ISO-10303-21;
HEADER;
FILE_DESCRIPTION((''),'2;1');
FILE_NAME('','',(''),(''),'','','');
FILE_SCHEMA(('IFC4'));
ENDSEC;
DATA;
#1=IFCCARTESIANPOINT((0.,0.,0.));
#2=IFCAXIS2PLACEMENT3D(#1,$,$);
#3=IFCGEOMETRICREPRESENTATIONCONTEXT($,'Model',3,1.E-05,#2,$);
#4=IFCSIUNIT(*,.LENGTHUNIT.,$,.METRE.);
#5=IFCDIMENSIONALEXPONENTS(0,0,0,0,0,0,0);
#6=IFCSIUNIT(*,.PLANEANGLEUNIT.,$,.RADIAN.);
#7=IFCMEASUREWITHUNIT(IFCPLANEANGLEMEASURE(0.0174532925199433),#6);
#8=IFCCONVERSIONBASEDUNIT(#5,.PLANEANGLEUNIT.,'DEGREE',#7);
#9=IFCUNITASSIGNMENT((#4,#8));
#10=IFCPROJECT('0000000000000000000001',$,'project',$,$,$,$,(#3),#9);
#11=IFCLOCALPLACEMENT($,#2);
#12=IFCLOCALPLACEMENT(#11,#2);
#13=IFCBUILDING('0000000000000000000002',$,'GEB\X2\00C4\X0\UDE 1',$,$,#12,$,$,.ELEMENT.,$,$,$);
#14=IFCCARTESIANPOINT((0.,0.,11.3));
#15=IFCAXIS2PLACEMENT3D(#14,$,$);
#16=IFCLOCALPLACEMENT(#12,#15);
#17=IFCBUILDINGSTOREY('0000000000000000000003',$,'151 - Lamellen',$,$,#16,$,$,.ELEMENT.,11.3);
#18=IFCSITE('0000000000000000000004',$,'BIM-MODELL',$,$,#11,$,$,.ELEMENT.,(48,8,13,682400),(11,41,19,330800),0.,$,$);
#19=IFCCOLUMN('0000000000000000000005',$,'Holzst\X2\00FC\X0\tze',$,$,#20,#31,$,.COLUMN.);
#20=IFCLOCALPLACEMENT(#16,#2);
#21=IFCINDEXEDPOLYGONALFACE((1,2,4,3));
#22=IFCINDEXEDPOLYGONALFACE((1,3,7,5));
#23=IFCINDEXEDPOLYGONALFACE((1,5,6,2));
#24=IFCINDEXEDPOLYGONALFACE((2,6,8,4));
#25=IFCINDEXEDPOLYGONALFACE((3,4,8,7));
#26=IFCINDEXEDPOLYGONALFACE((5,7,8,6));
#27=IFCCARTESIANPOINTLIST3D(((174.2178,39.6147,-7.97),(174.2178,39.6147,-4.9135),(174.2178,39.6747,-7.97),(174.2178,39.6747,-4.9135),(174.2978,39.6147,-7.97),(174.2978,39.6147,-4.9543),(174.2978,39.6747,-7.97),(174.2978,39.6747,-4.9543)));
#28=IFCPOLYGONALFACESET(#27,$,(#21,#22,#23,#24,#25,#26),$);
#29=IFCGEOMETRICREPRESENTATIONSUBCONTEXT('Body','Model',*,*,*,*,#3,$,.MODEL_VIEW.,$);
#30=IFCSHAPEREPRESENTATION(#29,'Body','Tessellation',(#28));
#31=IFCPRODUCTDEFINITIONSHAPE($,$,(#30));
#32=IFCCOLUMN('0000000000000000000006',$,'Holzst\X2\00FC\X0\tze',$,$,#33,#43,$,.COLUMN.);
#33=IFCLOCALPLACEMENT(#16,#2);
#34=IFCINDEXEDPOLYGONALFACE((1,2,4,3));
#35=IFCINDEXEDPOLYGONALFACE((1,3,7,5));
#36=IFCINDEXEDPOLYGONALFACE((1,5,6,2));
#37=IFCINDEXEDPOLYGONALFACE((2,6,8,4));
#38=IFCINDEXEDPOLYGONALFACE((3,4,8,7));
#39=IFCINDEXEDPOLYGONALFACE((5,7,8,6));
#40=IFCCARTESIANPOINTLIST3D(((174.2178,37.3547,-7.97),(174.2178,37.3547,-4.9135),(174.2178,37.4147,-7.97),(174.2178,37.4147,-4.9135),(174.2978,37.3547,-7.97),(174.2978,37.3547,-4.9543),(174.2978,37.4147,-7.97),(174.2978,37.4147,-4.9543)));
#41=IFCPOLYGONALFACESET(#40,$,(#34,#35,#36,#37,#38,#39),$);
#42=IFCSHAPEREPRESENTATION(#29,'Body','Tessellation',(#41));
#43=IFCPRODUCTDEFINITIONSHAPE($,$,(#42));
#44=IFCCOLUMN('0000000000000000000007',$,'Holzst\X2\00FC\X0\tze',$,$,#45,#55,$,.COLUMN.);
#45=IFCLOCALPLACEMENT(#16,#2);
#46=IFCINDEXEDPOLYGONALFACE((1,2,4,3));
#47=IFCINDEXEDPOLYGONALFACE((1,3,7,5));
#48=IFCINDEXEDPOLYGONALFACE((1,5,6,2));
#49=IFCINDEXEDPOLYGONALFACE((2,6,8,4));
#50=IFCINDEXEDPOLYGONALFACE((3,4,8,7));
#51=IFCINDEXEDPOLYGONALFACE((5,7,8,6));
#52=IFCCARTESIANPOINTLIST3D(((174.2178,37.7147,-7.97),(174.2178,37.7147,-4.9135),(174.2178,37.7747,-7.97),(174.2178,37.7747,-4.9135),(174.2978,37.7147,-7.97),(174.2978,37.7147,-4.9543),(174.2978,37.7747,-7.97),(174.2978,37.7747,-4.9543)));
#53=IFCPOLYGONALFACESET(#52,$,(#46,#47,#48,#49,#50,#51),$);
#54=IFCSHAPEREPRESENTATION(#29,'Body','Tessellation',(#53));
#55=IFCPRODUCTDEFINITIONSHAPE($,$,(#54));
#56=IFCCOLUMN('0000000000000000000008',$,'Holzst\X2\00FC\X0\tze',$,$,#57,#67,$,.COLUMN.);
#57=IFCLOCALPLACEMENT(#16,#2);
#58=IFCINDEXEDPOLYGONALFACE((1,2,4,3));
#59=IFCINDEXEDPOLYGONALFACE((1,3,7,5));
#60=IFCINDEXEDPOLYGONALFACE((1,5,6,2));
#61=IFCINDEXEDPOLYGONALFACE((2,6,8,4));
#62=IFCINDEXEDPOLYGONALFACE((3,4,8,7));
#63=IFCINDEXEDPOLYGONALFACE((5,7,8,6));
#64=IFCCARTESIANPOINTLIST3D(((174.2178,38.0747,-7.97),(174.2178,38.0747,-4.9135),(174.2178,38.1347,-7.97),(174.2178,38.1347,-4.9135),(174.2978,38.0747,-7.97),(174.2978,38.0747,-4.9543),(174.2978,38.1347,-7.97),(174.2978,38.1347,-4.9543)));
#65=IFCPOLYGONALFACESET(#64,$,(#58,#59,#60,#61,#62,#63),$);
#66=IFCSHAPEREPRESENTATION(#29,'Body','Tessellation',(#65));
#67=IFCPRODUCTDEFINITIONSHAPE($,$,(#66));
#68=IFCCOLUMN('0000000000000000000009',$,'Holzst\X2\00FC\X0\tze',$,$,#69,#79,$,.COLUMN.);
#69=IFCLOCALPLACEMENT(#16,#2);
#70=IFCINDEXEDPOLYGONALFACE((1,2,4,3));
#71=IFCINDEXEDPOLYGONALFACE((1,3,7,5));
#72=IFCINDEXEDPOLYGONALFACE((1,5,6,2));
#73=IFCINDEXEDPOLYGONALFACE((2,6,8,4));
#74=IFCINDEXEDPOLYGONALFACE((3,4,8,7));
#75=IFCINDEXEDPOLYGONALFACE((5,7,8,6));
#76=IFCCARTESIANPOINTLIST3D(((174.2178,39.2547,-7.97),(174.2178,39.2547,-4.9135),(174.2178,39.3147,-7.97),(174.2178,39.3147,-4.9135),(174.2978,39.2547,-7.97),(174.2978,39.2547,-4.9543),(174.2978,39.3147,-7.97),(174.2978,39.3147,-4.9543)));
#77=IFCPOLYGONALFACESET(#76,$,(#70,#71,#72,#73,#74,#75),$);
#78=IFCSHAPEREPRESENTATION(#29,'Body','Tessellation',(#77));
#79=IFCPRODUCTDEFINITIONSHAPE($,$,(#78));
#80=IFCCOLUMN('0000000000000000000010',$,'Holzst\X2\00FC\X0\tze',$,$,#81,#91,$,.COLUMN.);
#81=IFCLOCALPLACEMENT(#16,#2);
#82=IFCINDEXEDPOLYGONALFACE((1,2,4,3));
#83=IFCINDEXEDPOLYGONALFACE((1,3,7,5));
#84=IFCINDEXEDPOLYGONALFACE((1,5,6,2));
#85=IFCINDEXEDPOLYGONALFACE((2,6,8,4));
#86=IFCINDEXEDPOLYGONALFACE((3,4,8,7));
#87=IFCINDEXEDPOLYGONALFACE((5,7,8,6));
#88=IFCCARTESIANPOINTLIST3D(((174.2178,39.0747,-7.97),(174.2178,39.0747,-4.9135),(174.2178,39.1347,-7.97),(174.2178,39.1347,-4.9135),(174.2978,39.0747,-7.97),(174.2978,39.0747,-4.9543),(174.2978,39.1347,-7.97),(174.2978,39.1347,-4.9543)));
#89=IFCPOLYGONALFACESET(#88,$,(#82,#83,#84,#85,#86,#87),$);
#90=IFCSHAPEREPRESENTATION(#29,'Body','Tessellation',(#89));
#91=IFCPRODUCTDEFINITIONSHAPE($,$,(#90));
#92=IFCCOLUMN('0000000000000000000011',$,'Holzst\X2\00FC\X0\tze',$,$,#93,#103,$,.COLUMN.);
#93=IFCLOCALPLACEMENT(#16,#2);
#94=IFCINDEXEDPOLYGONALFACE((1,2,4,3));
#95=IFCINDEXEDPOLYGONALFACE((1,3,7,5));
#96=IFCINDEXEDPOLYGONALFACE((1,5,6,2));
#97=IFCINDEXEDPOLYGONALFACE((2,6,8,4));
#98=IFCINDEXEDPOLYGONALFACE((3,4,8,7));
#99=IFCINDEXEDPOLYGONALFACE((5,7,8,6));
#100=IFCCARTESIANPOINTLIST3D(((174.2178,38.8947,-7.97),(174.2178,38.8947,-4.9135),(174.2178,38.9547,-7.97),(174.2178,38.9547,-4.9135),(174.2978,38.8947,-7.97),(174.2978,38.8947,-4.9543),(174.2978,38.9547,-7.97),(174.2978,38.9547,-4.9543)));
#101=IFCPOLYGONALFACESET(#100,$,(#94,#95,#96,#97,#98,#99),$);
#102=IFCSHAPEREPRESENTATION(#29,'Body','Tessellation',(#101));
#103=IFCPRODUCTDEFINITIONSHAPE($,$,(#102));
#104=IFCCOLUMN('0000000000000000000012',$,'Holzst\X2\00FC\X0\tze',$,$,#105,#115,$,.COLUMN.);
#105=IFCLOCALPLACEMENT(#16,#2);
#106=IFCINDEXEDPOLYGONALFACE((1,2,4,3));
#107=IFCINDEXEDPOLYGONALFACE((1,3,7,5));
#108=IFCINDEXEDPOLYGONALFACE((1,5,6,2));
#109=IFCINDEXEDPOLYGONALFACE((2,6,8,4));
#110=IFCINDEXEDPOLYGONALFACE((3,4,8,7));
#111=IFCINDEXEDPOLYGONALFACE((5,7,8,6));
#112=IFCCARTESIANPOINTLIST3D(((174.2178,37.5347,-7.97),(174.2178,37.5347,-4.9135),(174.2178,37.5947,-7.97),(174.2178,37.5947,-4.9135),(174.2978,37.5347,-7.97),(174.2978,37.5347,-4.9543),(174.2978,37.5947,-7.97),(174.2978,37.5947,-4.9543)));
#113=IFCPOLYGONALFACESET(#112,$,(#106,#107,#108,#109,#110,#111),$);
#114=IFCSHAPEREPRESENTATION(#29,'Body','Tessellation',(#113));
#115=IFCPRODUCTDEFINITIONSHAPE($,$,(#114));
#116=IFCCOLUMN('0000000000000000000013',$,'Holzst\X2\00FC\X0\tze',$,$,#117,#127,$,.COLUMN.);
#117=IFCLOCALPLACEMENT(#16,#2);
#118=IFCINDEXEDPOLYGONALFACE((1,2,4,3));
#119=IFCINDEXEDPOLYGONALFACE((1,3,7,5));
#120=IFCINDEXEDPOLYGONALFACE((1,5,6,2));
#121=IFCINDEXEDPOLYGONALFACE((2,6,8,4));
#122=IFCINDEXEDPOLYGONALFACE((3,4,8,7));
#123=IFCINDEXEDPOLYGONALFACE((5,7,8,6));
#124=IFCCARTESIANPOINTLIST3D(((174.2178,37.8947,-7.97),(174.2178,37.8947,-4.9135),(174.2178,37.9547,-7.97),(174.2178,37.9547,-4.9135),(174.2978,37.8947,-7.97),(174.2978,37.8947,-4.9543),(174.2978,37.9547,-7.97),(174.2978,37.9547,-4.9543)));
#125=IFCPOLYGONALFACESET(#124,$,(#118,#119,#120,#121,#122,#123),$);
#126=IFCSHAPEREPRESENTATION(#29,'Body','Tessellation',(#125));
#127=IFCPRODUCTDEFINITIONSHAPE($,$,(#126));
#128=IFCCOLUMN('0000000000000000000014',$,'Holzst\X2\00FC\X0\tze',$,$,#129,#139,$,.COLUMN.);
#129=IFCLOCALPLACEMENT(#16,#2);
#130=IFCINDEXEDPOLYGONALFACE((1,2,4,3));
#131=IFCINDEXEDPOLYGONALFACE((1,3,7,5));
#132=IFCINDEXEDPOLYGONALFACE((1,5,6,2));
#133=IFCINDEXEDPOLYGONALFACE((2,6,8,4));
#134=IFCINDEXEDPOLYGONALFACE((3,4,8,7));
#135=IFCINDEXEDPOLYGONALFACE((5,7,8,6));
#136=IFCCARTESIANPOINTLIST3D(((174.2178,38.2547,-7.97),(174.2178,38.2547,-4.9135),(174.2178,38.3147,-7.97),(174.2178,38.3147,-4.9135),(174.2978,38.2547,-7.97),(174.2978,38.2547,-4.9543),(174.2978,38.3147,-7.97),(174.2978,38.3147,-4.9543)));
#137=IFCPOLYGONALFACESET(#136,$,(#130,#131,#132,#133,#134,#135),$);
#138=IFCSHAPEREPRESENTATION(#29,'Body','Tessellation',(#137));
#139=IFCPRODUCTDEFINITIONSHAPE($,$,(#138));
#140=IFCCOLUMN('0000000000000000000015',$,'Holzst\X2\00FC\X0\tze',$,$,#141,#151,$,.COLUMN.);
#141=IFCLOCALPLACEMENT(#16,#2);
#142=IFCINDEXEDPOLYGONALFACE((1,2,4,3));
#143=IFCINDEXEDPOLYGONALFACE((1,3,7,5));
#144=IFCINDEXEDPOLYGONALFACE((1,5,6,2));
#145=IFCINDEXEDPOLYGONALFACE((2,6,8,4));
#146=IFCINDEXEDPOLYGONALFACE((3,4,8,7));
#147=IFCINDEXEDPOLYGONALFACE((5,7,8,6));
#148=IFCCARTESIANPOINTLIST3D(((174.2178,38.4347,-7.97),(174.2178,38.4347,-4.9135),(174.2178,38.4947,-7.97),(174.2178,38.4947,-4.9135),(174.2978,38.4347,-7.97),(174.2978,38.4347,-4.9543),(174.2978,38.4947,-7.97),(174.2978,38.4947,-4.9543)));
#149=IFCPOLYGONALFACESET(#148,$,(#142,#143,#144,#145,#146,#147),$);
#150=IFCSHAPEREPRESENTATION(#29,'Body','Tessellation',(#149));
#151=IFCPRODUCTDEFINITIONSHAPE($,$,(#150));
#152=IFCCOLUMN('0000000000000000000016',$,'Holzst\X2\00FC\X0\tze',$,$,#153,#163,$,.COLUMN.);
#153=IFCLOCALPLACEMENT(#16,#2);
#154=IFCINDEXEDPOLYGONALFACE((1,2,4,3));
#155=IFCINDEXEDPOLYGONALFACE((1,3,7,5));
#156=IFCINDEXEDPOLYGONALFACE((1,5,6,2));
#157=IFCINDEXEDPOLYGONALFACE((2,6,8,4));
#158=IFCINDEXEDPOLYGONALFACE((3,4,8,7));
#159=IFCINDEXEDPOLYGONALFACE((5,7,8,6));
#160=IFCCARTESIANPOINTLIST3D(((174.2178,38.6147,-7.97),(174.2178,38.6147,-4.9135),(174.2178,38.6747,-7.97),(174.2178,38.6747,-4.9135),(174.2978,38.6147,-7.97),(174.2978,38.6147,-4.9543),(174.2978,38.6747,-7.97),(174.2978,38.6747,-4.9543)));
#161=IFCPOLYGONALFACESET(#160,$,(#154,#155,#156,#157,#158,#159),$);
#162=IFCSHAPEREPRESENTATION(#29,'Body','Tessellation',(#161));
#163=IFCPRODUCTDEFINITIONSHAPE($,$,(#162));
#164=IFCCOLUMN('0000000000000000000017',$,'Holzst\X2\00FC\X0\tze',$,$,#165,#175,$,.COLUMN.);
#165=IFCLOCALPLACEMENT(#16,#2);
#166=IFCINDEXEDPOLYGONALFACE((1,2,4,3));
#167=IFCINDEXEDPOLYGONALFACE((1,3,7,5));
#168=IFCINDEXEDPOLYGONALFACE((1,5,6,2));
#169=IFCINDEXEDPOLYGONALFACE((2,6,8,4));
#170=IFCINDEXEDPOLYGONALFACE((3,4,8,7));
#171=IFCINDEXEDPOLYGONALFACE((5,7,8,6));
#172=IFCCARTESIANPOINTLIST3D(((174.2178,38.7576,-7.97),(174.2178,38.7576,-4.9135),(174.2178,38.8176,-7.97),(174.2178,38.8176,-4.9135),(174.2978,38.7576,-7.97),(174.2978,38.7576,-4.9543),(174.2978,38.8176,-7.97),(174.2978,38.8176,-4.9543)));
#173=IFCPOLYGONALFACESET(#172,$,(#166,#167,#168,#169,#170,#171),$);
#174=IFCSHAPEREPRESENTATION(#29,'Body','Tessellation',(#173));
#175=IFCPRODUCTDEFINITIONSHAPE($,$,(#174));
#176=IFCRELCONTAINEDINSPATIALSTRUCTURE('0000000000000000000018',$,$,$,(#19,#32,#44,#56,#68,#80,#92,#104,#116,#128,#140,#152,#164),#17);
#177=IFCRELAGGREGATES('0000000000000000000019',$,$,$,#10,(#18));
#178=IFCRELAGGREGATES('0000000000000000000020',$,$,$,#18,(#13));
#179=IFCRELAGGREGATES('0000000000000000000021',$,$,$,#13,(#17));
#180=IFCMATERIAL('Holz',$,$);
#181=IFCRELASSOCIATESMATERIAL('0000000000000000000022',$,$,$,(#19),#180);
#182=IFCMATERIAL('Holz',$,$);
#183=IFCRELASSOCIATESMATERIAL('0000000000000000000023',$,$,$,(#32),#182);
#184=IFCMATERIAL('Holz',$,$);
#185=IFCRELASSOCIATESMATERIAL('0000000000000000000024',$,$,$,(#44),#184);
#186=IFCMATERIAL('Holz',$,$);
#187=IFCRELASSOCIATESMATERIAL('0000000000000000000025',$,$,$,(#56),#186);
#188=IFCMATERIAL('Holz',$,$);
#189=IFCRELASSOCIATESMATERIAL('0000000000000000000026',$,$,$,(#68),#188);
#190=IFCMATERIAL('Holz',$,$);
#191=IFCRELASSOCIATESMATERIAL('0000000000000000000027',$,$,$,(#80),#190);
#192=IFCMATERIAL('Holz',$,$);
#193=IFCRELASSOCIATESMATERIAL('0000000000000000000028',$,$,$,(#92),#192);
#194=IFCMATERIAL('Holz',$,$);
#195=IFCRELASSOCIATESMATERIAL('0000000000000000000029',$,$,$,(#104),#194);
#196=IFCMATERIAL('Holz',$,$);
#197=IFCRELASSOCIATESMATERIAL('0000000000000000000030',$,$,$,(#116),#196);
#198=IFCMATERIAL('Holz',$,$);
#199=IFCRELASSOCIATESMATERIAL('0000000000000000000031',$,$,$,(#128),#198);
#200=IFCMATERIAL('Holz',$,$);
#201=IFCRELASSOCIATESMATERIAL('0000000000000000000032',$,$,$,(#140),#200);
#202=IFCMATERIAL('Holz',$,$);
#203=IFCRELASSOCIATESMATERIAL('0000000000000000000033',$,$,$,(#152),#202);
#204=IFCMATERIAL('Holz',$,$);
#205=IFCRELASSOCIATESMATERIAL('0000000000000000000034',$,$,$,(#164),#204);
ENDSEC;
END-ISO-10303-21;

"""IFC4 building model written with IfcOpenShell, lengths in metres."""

from ifc_helpers import new_model, entity, si_unit, converted_unit, frame, frame_2d, origin, origin_with_axes, place, context, subcontext, project, spatial, rectangle, extrude, clip, halfspace, material, element, save


model = new_model("IFC4")

# Units and contexts
model_context = context("Model", 3, precision=1e-05, world=origin())
body_context = subcontext(model_context, "Body", "Model", "MODEL_VIEW")
ifc_project = project(units=[si_unit("LENGTHUNIT", "METRE"), converted_unit("PLANEANGLEUNIT", "DEGREE", entity("IfcPlaneAngleMeasure", 0.0174532925199433), si_unit("PLANEANGLEUNIT", "RADIAN"), dimensions=[0, 0, 0, 0, 0, 0, 0])], contexts=[model_context])

# Site, building, storey
site_placement = place(None, origin())
site = spatial("IfcSite", under=ifc_project, at=site_placement, Name="BIM-MODELL", CompositionType="ELEMENT", RefLatitude=(48, 8, 13, 682400), RefLongitude=(11, 41, 19, 330800), RefElevation=0.0)
building_placement = place(site_placement, origin())
building = spatial("IfcBuilding", under=site, at=building_placement, Name="GEBÄUDE 1", CompositionType="ELEMENT")
storey_placement = place(building_placement, frame((0.0, 0.0, 11.3)))
storey = spatial("IfcBuildingStorey", under=building, at=storey_placement, Name="151 - Lamellen", CompositionType="ELEMENT", Elevation=11.3)

# Columns
ifc_material_1 = material(Name="Holz")
column_1_placement = place(storey_placement, frame((174.2978, 39.6147, -7.97)))
element("IfcColumn", 1, at=column_1_placement, inside=storey, material=ifc_material_1, Name="Holzstütze", PredefinedType="COLUMN", context=body_context, shape_type="Clipping", body=[
    clip(extrude(rectangle(XDim=0.06, YDim=0.08, at=frame_2d((-0.04, 0.03), x_axis=(0.0, 1.0))), origin_with_axes(), (0.0, 0.0, 1.0), 3.0565), halfspace(frame((-0.04, 0.03, 3.0361), z_axis=(-0.45399, 0.0, -0.891007), x_axis=(0.891007, 0.0, -0.45399)), True)),
])
ifc_material_2 = material(Name="Holz")
column_2_placement = place(storey_placement, frame((174.2978, 37.3547, -7.97)))
element("IfcColumn", 2, at=column_2_placement, inside=storey, material=ifc_material_2, Name="Holzstütze", PredefinedType="COLUMN", context=body_context, shape_type="Clipping", body=[
    clip(extrude(rectangle(XDim=0.06, YDim=0.08, at=frame_2d((-0.04, 0.03), x_axis=(0.0, 1.0))), origin_with_axes(), (0.0, 0.0, 1.0), 3.0565), halfspace(frame((-0.04, 0.03, 3.0361), z_axis=(-0.45399, 0.0, -0.891007), x_axis=(0.891007, 0.0, -0.45399)), True)),
])
ifc_material_3 = material(Name="Holz")
column_3_placement = place(storey_placement, frame((174.2978, 37.7147, -7.97)))
element("IfcColumn", 3, at=column_3_placement, inside=storey, material=ifc_material_3, Name="Holzstütze", PredefinedType="COLUMN", context=body_context, shape_type="Clipping", body=[
    clip(extrude(rectangle(XDim=0.06, YDim=0.08, at=frame_2d((-0.04, 0.03), x_axis=(0.0, 1.0))), origin_with_axes(), (0.0, 0.0, 1.0), 3.0565), halfspace(frame((-0.04, 0.03, 3.0361), z_axis=(-0.45399, 0.0, -0.891007), x_axis=(0.891007, 0.0, -0.45399)), True)),
])
ifc_material_4 = material(Name="Holz")
column_4_placement = place(storey_placement, frame((174.2978, 38.0747, -7.97)))
element("IfcColumn", 4, at=column_4_placement, inside=storey, material=ifc_material_4, Name="Holzstütze", PredefinedType="COLUMN", context=body_context, shape_type="Clipping", body=[
    clip(extrude(rectangle(XDim=0.06, YDim=0.08, at=frame_2d((-0.04, 0.03), x_axis=(0.0, 1.0))), origin_with_axes(), (0.0, 0.0, 1.0), 3.0565), halfspace(frame((-0.04, 0.03, 3.0361), z_axis=(-0.45399, 0.0, -0.891007), x_axis=(0.891007, 0.0, -0.45399)), True)),
])
ifc_material_5 = material(Name="Holz")
column_5_placement = place(storey_placement, frame((174.2978, 39.2547, -7.97)))
element("IfcColumn", 5, at=column_5_placement, inside=storey, material=ifc_material_5, Name="Holzstütze", PredefinedType="COLUMN", context=body_context, shape_type="Clipping", body=[
    clip(extrude(rectangle(XDim=0.06, YDim=0.08, at=frame_2d((-0.04, 0.03), x_axis=(0.0, 1.0))), origin_with_axes(), (0.0, 0.0, 1.0), 3.0565), halfspace(frame((-0.04, 0.03, 3.0361), z_axis=(-0.45399, 0.0, -0.891007), x_axis=(0.891007, 0.0, -0.45399)), True)),
])
ifc_material_6 = material(Name="Holz")
column_6_placement = place(storey_placement, frame((174.2978, 39.0747, -7.97)))
element("IfcColumn", 6, at=column_6_placement, inside=storey, material=ifc_material_6, Name="Holzstütze", PredefinedType="COLUMN", context=body_context, shape_type="Clipping", body=[
    clip(extrude(rectangle(XDim=0.06, YDim=0.08, at=frame_2d((-0.04, 0.03), x_axis=(0.0, 1.0))), origin_with_axes(), (0.0, 0.0, 1.0), 3.0565), halfspace(frame((-0.04, 0.03, 3.0361), z_axis=(-0.45399, 0.0, -0.891007), x_axis=(0.891007, 0.0, -0.45399)), True)),
])
ifc_material_7 = material(Name="Holz")
column_7_placement = place(storey_placement, frame((174.2978, 38.8947, -7.97)))
element("IfcColumn", 7, at=column_7_placement, inside=storey, material=ifc_material_7, Name="Holzstütze", PredefinedType="COLUMN", context=body_context, shape_type="Clipping", body=[
    clip(extrude(rectangle(XDim=0.06, YDim=0.08, at=frame_2d((-0.04, 0.03), x_axis=(0.0, 1.0))), origin_with_axes(), (0.0, 0.0, 1.0), 3.0565), halfspace(frame((-0.04, 0.03, 3.0361), z_axis=(-0.45399, 0.0, -0.891007), x_axis=(0.891007, 0.0, -0.45399)), True)),
])
ifc_material_8 = material(Name="Holz")
column_8_placement = place(storey_placement, frame((174.2978, 37.5347, -7.97)))
element("IfcColumn", 8, at=column_8_placement, inside=storey, material=ifc_material_8, Name="Holzstütze", PredefinedType="COLUMN", context=body_context, shape_type="Clipping", body=[
    clip(extrude(rectangle(XDim=0.06, YDim=0.08, at=frame_2d((-0.04, 0.03), x_axis=(0.0, 1.0))), origin_with_axes(), (0.0, 0.0, 1.0), 3.0565), halfspace(frame((-0.04, 0.03, 3.0361), z_axis=(-0.45399, 0.0, -0.891007), x_axis=(0.891007, 0.0, -0.45399)), True)),
])
ifc_material_9 = material(Name="Holz")
column_9_placement = place(storey_placement, frame((174.2978, 37.8947, -7.97)))
element("IfcColumn", 9, at=column_9_placement, inside=storey, material=ifc_material_9, Name="Holzstütze", PredefinedType="COLUMN", context=body_context, shape_type="Clipping", body=[
    clip(extrude(rectangle(XDim=0.06, YDim=0.08, at=frame_2d((-0.04, 0.03), x_axis=(0.0, 1.0))), origin_with_axes(), (0.0, 0.0, 1.0), 3.0565), halfspace(frame((-0.04, 0.03, 3.0361), z_axis=(-0.45399, 0.0, -0.891007), x_axis=(0.891007, 0.0, -0.45399)), True)),
])
ifc_material_10 = material(Name="Holz")
column_10_placement = place(storey_placement, frame((174.2978, 38.2547, -7.97)))
element("IfcColumn", 10, at=column_10_placement, inside=storey, material=ifc_material_10, Name="Holzstütze", PredefinedType="COLUMN", context=body_context, shape_type="Clipping", body=[
    clip(extrude(rectangle(XDim=0.06, YDim=0.08, at=frame_2d((-0.04, 0.03), x_axis=(0.0, 1.0))), origin_with_axes(), (0.0, 0.0, 1.0), 3.0565), halfspace(frame((-0.04, 0.03, 3.0361), z_axis=(-0.45399, 0.0, -0.891007), x_axis=(0.891007, 0.0, -0.45399)), True)),
])
ifc_material_11 = material(Name="Holz")
column_11_placement = place(storey_placement, frame((174.2978, 38.4347, -7.97)))
element("IfcColumn", 11, at=column_11_placement, inside=storey, material=ifc_material_11, Name="Holzstütze", PredefinedType="COLUMN", context=body_context, shape_type="Clipping", body=[
    clip(extrude(rectangle(XDim=0.06, YDim=0.08, at=frame_2d((-0.04, 0.03), x_axis=(0.0, 1.0))), origin_with_axes(), (0.0, 0.0, 1.0), 3.0565), halfspace(frame((-0.04, 0.03, 3.0361), z_axis=(-0.45399, 0.0, -0.891007), x_axis=(0.891007, 0.0, -0.45399)), True)),
])
ifc_material_12 = material(Name="Holz")
column_12_placement = place(storey_placement, frame((174.2978, 38.6147, -7.97)))
element("IfcColumn", 12, at=column_12_placement, inside=storey, material=ifc_material_12, Name="Holzstütze", PredefinedType="COLUMN", context=body_context, shape_type="Clipping", body=[
    clip(extrude(rectangle(XDim=0.06, YDim=0.08, at=frame_2d((-0.04, 0.03), x_axis=(0.0, 1.0))), origin_with_axes(), (0.0, 0.0, 1.0), 3.0565), halfspace(frame((-0.04, 0.03, 3.0361), z_axis=(-0.45399, 0.0, -0.891007), x_axis=(0.891007, 0.0, -0.45399)), True)),
])
ifc_material_13 = material(Name="Holz")
column_13_placement = place(storey_placement, frame((174.2978, 38.7576, -7.97)))
element("IfcColumn", 13, at=column_13_placement, inside=storey, material=ifc_material_13, Name="Holzstütze", PredefinedType="COLUMN", context=body_context, shape_type="Clipping", body=[
    clip(extrude(rectangle(XDim=0.06, YDim=0.08, at=frame_2d((-0.04, 0.03), x_axis=(0.0, 1.0))), origin_with_axes(), (0.0, 0.0, 1.0), 3.0565), halfspace(frame((-0.04, 0.03, 3.0361), z_axis=(-0.45399, 0.0, -0.891007), x_axis=(0.891007, 0.0, -0.45399)), True)),
])

save(model, "model.ifc")
